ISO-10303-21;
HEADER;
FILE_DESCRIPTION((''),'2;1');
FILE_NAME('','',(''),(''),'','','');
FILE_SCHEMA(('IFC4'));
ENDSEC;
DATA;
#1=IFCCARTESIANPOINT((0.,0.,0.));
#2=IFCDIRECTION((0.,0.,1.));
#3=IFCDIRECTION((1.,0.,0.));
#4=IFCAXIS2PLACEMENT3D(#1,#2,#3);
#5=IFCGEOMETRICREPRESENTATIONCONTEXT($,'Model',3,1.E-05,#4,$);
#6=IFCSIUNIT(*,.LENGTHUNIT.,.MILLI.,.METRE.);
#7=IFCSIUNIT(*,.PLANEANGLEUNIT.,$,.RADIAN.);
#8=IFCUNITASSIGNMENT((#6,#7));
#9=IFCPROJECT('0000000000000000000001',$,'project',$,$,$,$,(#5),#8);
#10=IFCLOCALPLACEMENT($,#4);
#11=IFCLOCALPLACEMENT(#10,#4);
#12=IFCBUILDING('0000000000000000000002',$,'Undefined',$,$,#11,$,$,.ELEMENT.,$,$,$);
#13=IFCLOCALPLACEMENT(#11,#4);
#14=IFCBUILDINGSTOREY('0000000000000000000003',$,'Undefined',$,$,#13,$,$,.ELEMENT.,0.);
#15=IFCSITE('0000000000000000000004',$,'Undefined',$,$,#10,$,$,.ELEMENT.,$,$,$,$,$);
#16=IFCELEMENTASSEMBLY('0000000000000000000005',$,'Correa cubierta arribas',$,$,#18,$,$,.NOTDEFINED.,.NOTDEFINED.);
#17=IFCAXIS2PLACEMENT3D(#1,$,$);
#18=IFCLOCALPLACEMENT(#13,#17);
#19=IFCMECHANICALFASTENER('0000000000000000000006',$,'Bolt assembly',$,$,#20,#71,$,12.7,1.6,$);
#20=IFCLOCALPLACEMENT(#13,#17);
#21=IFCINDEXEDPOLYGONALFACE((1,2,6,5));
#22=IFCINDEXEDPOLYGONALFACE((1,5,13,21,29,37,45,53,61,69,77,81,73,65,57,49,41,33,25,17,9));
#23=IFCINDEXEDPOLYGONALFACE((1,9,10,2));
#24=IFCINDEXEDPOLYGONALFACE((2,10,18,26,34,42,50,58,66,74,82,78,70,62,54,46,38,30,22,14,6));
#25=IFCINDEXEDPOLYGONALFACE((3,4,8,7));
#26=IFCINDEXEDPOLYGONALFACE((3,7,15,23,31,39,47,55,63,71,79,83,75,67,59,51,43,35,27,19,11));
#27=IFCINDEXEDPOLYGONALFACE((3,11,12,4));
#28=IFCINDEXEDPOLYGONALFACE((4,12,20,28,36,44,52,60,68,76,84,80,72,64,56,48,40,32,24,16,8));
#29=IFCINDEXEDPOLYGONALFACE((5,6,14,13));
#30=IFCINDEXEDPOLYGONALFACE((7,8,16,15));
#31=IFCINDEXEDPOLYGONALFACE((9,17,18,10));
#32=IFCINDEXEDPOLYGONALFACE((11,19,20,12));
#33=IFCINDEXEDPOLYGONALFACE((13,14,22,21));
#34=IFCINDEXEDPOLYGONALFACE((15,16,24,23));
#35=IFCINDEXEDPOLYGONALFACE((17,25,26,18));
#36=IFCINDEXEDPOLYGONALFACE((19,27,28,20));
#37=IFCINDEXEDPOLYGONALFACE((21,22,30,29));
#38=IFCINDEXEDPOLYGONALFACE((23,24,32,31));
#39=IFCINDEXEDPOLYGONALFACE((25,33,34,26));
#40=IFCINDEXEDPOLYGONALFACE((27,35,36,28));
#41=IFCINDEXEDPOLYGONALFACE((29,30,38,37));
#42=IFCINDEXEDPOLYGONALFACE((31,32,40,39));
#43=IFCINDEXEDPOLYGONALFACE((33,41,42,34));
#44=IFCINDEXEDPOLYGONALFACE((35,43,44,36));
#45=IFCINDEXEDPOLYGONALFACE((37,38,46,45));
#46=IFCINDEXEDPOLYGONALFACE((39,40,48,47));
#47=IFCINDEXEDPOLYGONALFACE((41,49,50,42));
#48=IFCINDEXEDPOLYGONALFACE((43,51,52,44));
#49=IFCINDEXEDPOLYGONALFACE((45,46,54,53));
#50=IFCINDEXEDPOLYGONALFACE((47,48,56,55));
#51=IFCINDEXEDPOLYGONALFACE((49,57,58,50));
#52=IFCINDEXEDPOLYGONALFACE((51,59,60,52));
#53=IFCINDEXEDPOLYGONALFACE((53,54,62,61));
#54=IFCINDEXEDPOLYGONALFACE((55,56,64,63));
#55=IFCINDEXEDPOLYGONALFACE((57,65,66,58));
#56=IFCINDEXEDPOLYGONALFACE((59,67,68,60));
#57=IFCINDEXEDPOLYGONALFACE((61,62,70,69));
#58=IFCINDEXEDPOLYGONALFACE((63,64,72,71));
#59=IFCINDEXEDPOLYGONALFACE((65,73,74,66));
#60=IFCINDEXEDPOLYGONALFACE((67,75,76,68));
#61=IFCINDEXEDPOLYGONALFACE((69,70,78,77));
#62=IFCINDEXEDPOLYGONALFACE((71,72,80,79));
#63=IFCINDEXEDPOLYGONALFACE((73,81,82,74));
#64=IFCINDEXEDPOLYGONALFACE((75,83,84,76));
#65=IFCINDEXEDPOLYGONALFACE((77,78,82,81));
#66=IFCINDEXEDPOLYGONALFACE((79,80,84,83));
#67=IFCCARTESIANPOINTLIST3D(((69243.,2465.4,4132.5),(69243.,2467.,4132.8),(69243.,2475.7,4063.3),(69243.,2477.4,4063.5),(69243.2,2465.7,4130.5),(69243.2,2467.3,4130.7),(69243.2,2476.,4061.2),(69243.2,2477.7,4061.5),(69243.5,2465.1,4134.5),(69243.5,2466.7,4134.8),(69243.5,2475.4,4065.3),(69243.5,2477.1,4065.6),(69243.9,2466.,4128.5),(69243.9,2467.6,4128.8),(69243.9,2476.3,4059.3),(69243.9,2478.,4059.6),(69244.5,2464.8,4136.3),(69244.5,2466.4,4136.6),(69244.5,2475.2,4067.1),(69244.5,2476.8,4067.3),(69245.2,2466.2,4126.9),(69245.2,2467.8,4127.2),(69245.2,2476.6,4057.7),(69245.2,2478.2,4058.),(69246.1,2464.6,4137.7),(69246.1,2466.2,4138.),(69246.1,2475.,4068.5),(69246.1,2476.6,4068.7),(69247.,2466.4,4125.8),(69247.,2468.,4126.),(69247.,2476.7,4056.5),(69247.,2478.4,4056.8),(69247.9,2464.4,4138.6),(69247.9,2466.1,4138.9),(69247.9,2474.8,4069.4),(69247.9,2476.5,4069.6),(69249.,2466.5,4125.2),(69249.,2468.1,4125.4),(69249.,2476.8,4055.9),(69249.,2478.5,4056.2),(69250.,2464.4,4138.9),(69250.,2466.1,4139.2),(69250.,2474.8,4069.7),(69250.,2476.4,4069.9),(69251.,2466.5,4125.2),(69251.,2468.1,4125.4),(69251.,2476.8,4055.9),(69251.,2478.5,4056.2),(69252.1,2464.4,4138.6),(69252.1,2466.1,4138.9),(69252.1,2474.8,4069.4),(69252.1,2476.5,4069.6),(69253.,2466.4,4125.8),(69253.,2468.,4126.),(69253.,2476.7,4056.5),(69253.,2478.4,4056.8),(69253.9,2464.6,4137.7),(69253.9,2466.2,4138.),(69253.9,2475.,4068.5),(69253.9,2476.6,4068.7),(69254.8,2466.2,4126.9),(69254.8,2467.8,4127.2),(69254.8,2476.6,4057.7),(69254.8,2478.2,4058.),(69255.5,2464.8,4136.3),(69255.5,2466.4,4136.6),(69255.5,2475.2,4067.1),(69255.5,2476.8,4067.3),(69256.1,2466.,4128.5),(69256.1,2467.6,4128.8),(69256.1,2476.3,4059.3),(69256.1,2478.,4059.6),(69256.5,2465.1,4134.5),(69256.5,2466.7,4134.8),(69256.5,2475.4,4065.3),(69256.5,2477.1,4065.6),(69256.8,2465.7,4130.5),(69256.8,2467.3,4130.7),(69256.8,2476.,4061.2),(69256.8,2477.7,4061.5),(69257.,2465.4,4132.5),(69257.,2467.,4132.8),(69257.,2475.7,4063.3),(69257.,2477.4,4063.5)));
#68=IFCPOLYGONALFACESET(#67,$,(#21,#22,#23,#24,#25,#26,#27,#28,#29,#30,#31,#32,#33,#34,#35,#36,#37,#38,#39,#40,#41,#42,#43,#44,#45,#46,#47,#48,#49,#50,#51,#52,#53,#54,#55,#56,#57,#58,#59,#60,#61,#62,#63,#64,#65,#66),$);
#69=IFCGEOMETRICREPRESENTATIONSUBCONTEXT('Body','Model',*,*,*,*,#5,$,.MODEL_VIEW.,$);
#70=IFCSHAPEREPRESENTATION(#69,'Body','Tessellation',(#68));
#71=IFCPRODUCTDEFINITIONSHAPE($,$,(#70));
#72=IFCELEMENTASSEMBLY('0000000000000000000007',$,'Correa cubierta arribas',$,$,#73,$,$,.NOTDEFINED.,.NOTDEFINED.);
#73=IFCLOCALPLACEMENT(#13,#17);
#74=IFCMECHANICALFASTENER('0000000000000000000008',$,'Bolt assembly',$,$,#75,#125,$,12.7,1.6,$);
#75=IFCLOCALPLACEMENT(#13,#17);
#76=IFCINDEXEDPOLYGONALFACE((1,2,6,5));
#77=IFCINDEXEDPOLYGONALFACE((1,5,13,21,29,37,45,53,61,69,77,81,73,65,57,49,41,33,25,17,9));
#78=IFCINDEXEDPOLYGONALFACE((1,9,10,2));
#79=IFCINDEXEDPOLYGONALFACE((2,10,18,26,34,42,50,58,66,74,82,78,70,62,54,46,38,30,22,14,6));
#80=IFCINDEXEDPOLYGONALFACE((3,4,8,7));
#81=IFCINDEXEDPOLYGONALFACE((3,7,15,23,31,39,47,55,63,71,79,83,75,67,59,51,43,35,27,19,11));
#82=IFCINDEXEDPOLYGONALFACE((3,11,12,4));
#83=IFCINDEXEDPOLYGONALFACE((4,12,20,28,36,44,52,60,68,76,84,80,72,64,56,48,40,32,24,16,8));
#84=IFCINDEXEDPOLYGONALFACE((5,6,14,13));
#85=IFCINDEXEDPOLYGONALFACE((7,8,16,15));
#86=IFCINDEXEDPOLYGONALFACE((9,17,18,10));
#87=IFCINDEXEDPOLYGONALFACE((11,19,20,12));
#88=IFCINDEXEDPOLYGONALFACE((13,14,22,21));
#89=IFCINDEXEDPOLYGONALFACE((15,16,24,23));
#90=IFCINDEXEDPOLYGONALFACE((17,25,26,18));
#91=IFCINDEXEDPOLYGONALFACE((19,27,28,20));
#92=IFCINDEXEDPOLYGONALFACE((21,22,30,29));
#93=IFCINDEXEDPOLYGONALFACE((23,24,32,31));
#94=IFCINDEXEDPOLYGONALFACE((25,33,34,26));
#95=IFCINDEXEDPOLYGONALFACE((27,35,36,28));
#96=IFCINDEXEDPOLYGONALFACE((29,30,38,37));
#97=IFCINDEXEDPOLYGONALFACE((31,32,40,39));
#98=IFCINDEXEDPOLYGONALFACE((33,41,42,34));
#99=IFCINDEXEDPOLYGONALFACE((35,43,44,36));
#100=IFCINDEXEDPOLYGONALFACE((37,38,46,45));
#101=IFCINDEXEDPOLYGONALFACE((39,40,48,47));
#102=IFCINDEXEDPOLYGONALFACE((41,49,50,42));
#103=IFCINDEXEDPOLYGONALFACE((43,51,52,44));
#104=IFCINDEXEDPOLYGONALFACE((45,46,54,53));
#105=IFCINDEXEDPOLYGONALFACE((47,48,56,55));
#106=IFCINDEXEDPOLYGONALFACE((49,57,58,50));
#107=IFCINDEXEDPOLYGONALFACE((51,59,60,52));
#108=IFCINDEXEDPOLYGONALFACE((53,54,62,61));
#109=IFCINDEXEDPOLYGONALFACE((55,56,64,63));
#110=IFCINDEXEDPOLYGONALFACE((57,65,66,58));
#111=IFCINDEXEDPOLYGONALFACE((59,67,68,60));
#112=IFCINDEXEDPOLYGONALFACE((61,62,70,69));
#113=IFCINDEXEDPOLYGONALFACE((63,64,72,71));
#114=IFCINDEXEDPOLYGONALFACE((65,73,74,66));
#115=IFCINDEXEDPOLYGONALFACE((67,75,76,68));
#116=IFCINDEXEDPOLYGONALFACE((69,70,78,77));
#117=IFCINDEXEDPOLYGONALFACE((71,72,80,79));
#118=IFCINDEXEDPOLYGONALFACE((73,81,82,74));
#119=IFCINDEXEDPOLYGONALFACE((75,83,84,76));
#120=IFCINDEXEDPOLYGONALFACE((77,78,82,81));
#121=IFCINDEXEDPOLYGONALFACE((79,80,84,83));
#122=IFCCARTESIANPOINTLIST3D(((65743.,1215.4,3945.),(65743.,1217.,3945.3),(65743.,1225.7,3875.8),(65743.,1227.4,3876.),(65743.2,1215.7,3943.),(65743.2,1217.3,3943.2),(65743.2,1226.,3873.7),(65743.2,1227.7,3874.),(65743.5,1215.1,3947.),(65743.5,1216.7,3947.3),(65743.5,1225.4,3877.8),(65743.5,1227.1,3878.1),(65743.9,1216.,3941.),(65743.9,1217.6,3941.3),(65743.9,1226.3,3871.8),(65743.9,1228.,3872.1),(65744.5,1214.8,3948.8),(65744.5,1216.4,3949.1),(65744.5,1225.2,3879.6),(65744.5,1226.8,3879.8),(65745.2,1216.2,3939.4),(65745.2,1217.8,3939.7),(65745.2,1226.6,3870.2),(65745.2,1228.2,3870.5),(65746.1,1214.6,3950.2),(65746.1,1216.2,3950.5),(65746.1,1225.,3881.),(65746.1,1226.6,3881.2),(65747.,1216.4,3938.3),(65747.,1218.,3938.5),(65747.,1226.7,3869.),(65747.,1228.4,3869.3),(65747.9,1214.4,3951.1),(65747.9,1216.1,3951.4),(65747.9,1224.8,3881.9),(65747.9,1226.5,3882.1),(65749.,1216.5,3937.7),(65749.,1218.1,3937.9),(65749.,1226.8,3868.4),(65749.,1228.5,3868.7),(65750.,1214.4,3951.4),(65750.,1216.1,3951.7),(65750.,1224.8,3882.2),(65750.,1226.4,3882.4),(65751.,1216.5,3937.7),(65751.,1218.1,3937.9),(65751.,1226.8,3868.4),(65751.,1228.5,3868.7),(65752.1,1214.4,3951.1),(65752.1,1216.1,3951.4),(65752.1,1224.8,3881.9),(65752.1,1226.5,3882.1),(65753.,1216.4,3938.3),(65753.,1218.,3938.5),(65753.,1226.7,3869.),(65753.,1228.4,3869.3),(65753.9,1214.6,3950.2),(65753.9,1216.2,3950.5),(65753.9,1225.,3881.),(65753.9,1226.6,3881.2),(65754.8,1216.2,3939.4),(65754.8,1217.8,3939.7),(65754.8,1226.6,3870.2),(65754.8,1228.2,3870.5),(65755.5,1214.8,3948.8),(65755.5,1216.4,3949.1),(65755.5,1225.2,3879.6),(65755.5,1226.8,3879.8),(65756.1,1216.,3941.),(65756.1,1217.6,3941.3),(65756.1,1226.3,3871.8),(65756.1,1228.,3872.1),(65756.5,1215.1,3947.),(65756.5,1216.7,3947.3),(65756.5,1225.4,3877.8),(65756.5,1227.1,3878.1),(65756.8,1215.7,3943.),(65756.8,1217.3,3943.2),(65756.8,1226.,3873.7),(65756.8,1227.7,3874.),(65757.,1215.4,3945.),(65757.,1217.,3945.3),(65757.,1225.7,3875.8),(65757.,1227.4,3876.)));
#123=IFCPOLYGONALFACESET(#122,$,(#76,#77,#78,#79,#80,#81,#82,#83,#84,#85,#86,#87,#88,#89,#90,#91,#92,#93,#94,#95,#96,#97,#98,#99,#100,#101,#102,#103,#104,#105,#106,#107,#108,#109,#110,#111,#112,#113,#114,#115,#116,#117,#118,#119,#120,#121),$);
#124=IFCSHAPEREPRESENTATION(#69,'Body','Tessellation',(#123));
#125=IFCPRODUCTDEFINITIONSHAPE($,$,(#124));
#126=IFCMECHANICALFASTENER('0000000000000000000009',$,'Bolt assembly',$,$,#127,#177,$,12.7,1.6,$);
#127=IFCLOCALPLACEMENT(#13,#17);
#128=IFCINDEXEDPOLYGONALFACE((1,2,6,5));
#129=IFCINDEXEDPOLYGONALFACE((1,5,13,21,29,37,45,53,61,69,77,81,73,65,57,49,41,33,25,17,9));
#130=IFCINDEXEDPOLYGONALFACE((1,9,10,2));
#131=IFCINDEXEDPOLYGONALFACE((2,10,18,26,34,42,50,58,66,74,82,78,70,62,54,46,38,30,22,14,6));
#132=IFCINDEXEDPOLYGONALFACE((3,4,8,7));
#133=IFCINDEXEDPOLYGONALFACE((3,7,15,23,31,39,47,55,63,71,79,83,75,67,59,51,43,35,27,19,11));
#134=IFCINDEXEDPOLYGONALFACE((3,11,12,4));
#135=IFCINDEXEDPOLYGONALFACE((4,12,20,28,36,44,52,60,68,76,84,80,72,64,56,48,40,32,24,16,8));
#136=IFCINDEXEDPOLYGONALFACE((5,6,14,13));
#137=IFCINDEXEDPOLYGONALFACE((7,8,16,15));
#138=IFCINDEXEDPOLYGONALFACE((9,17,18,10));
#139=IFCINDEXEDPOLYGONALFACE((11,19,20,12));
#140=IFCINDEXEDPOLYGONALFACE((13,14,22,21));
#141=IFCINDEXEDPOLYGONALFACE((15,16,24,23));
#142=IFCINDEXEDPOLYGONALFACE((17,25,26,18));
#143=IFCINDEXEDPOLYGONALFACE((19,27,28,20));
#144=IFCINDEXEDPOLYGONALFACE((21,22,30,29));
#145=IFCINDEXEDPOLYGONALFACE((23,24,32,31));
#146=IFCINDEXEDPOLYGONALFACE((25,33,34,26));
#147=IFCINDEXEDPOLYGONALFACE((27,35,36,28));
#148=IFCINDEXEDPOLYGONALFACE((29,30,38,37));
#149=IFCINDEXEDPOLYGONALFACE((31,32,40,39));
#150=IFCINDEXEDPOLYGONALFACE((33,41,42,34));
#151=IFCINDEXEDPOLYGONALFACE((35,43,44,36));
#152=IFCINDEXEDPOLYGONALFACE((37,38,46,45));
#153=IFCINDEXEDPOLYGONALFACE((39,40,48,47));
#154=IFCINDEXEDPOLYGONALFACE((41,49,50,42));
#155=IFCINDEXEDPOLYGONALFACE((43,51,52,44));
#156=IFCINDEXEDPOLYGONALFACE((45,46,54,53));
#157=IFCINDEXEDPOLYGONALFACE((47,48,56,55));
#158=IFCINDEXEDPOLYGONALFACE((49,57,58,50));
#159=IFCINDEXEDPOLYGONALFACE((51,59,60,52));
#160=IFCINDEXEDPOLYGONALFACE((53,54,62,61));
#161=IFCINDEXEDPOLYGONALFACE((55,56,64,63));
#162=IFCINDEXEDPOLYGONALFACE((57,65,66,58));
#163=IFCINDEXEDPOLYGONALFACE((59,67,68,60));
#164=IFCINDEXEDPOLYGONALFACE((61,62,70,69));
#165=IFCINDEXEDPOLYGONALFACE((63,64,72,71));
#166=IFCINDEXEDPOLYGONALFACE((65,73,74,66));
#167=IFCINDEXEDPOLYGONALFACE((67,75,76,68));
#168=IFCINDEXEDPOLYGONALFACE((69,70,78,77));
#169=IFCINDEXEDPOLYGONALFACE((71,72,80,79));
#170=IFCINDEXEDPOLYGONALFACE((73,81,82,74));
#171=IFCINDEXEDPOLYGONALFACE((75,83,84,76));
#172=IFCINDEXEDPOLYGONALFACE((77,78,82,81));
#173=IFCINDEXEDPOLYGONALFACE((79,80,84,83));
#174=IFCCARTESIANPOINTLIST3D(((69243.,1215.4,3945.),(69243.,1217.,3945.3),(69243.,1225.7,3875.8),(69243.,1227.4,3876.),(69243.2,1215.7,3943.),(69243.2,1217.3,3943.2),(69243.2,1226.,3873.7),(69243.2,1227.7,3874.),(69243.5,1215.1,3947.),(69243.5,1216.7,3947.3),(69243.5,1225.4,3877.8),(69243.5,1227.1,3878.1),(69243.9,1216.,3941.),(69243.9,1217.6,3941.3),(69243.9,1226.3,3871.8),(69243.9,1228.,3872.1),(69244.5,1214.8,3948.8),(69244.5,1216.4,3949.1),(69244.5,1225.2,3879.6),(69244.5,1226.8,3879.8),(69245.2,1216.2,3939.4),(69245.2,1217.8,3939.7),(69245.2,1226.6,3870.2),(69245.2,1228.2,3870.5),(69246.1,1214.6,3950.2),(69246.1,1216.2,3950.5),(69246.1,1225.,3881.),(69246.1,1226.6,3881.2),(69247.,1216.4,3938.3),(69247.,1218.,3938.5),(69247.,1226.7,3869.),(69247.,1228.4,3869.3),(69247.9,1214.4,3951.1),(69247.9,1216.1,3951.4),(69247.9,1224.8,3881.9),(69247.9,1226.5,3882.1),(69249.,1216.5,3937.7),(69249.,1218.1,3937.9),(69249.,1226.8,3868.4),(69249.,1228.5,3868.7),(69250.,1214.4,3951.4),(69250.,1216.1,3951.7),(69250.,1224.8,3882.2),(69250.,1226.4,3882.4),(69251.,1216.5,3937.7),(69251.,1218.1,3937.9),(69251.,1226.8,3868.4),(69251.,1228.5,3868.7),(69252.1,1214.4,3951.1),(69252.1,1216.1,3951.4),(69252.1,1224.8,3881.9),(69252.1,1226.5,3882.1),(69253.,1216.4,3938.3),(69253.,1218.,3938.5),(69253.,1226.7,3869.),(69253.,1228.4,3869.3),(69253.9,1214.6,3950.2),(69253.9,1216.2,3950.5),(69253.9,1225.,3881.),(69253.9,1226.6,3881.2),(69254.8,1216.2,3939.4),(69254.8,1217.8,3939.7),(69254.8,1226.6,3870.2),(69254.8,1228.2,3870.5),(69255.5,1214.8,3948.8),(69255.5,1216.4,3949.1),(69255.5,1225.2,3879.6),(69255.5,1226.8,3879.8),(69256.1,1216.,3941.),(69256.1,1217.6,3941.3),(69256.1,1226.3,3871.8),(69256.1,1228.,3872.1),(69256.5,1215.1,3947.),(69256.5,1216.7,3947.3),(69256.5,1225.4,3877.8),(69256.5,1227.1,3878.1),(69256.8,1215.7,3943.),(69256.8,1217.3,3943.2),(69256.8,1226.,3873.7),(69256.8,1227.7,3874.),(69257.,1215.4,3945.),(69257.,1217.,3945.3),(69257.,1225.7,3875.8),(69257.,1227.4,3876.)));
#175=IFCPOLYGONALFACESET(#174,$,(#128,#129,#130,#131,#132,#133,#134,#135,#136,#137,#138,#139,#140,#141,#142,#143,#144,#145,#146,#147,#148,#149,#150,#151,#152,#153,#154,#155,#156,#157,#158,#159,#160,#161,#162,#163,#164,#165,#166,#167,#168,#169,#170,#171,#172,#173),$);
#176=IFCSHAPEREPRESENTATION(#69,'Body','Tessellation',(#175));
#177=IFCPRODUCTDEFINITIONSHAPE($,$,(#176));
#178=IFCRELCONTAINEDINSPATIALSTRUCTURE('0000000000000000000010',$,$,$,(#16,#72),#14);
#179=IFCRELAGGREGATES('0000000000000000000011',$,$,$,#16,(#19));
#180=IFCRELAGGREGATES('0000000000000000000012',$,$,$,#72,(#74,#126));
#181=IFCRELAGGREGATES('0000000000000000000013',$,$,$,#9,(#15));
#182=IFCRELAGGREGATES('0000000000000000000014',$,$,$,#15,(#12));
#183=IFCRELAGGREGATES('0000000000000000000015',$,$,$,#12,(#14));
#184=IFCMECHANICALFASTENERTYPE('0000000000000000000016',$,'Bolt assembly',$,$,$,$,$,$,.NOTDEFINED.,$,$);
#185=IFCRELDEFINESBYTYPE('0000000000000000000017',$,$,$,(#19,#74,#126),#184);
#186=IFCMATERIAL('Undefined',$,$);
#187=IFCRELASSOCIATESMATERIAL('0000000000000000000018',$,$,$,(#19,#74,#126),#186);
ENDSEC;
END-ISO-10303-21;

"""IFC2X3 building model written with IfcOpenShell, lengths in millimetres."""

from ifc_helpers import new_model, si_unit, frame, origin_with_axes, origin_2d_with_axis, place, context, subcontext, project, spatial, circle, extrude, source, transform, mapped, material, type_object, element, aggregate, save


model = new_model("IFC2X3")

# Units and contexts
model_context = context("Model", 3, precision=1e-05, world=origin_with_axes())
body_context = subcontext(model_context, "Body", "Model", "MODEL_VIEW")
ifc_project = project(units=[si_unit("LENGTHUNIT", "METRE", prefix="MILLI"), si_unit("PLANEANGLEUNIT", "RADIAN")], contexts=[model_context])

# Site, building, storey
site_placement = place(None, origin_with_axes())
site = spatial("IfcSite", under=ifc_project, at=site_placement, Name="Undefined", CompositionType="ELEMENT")
building_placement = place(site_placement, origin_with_axes())
building = spatial("IfcBuilding", under=site, at=building_placement, Name="Undefined", CompositionType="ELEMENT")
storey_placement = place(building_placement, origin_with_axes())
storey = spatial("IfcBuildingStorey", under=building, at=storey_placement, Name="Undefined", CompositionType="ELEMENT", Elevation=0.0)

# Shared definitions
ifc_material_1 = material(Name="Undefined")
mechanical_fastener_type = type_object("IfcMechanicalFastenerType", Name="Bolt assembly")

# Element assemblies, mechanical fasteners
assembly_1_placement = place(storey_placement, origin_with_axes())
assembly_1 = element("IfcElementAssembly", 1, at=assembly_1_placement, inside=storey, Name="Correa cubierta arribas", AssemblyPlace="NOTDEFINED", PredefinedType="NOTDEFINED")
shared_shape_1 = source(origin_with_axes(), body_context, "Body", "SweptSolid", [
    extrude(circle(Radius=7.0, at=origin_2d_with_axis()), frame((0.0, 6.4, 0.0), z_axis=(0.0, 1.0, 0.0), x_axis=(1.0, 0.0, 0.0)), (0.0, 0.0, 1.0), 1.7),
])
mechanical_fastener_1_placement = place(assembly_1_placement, frame((69250.0, 2483.8, 4064.0), z_axis=(1.0, 0.0, 0.0), x_axis=(0.0, -0.148209, 0.988956)))
mechanical_fastener_1 = element("IfcMechanicalFastener", 2, at=mechanical_fastener_1_placement, type_object=mechanical_fastener_type, material=ifc_material_1, Name="Bolt assembly", NominalDiameter=12.7, NominalLength=1.6, context=body_context, shape_type="MappedRepresentation", body=[
    mapped(shared_shape_1, transform((0.0, 0.0, 0.0))),
    mapped(shared_shape_1, transform((70.0, 0.0, 0.0))),
])
aggregate(assembly_1, [mechanical_fastener_1])
assembly_2_placement = place(storey_placement, origin_with_axes())
assembly_2 = element("IfcElementAssembly", 3, at=assembly_2_placement, inside=storey, Name="Correa cubierta arribas", AssemblyPlace="NOTDEFINED", PredefinedType="NOTDEFINED")
mechanical_fastener_2_placement = place(assembly_2_placement, frame((65750.0, 1233.8, 3876.5), z_axis=(1.0, 0.0, 0.0), x_axis=(0.0, -0.148209, 0.988956)))
mechanical_fastener_2 = element("IfcMechanicalFastener", 4, at=mechanical_fastener_2_placement, type_object=mechanical_fastener_type, material=ifc_material_1, Name="Bolt assembly", NominalDiameter=12.7, NominalLength=1.6, context=body_context, shape_type="MappedRepresentation", body=[
    mapped(shared_shape_1, transform((0.0, 0.0, 0.0))),
    mapped(shared_shape_1, transform((70.0, 0.0, 0.0))),
])
mechanical_fastener_3_placement = place(assembly_2_placement, frame((69250.0, 1233.8, 3876.5), z_axis=(1.0, 0.0, 0.0), x_axis=(0.0, -0.148209, 0.988956)))
mechanical_fastener_3 = element("IfcMechanicalFastener", 5, at=mechanical_fastener_3_placement, type_object=mechanical_fastener_type, material=ifc_material_1, Name="Bolt assembly", NominalDiameter=12.7, NominalLength=1.6, context=body_context, shape_type="MappedRepresentation", body=[
    mapped(shared_shape_1, transform((0.0, 0.0, 0.0))),
    mapped(shared_shape_1, transform((70.0, 0.0, 0.0))),
])
aggregate(assembly_2, [mechanical_fastener_2, mechanical_fastener_3])

save(model, "model.ifc")
